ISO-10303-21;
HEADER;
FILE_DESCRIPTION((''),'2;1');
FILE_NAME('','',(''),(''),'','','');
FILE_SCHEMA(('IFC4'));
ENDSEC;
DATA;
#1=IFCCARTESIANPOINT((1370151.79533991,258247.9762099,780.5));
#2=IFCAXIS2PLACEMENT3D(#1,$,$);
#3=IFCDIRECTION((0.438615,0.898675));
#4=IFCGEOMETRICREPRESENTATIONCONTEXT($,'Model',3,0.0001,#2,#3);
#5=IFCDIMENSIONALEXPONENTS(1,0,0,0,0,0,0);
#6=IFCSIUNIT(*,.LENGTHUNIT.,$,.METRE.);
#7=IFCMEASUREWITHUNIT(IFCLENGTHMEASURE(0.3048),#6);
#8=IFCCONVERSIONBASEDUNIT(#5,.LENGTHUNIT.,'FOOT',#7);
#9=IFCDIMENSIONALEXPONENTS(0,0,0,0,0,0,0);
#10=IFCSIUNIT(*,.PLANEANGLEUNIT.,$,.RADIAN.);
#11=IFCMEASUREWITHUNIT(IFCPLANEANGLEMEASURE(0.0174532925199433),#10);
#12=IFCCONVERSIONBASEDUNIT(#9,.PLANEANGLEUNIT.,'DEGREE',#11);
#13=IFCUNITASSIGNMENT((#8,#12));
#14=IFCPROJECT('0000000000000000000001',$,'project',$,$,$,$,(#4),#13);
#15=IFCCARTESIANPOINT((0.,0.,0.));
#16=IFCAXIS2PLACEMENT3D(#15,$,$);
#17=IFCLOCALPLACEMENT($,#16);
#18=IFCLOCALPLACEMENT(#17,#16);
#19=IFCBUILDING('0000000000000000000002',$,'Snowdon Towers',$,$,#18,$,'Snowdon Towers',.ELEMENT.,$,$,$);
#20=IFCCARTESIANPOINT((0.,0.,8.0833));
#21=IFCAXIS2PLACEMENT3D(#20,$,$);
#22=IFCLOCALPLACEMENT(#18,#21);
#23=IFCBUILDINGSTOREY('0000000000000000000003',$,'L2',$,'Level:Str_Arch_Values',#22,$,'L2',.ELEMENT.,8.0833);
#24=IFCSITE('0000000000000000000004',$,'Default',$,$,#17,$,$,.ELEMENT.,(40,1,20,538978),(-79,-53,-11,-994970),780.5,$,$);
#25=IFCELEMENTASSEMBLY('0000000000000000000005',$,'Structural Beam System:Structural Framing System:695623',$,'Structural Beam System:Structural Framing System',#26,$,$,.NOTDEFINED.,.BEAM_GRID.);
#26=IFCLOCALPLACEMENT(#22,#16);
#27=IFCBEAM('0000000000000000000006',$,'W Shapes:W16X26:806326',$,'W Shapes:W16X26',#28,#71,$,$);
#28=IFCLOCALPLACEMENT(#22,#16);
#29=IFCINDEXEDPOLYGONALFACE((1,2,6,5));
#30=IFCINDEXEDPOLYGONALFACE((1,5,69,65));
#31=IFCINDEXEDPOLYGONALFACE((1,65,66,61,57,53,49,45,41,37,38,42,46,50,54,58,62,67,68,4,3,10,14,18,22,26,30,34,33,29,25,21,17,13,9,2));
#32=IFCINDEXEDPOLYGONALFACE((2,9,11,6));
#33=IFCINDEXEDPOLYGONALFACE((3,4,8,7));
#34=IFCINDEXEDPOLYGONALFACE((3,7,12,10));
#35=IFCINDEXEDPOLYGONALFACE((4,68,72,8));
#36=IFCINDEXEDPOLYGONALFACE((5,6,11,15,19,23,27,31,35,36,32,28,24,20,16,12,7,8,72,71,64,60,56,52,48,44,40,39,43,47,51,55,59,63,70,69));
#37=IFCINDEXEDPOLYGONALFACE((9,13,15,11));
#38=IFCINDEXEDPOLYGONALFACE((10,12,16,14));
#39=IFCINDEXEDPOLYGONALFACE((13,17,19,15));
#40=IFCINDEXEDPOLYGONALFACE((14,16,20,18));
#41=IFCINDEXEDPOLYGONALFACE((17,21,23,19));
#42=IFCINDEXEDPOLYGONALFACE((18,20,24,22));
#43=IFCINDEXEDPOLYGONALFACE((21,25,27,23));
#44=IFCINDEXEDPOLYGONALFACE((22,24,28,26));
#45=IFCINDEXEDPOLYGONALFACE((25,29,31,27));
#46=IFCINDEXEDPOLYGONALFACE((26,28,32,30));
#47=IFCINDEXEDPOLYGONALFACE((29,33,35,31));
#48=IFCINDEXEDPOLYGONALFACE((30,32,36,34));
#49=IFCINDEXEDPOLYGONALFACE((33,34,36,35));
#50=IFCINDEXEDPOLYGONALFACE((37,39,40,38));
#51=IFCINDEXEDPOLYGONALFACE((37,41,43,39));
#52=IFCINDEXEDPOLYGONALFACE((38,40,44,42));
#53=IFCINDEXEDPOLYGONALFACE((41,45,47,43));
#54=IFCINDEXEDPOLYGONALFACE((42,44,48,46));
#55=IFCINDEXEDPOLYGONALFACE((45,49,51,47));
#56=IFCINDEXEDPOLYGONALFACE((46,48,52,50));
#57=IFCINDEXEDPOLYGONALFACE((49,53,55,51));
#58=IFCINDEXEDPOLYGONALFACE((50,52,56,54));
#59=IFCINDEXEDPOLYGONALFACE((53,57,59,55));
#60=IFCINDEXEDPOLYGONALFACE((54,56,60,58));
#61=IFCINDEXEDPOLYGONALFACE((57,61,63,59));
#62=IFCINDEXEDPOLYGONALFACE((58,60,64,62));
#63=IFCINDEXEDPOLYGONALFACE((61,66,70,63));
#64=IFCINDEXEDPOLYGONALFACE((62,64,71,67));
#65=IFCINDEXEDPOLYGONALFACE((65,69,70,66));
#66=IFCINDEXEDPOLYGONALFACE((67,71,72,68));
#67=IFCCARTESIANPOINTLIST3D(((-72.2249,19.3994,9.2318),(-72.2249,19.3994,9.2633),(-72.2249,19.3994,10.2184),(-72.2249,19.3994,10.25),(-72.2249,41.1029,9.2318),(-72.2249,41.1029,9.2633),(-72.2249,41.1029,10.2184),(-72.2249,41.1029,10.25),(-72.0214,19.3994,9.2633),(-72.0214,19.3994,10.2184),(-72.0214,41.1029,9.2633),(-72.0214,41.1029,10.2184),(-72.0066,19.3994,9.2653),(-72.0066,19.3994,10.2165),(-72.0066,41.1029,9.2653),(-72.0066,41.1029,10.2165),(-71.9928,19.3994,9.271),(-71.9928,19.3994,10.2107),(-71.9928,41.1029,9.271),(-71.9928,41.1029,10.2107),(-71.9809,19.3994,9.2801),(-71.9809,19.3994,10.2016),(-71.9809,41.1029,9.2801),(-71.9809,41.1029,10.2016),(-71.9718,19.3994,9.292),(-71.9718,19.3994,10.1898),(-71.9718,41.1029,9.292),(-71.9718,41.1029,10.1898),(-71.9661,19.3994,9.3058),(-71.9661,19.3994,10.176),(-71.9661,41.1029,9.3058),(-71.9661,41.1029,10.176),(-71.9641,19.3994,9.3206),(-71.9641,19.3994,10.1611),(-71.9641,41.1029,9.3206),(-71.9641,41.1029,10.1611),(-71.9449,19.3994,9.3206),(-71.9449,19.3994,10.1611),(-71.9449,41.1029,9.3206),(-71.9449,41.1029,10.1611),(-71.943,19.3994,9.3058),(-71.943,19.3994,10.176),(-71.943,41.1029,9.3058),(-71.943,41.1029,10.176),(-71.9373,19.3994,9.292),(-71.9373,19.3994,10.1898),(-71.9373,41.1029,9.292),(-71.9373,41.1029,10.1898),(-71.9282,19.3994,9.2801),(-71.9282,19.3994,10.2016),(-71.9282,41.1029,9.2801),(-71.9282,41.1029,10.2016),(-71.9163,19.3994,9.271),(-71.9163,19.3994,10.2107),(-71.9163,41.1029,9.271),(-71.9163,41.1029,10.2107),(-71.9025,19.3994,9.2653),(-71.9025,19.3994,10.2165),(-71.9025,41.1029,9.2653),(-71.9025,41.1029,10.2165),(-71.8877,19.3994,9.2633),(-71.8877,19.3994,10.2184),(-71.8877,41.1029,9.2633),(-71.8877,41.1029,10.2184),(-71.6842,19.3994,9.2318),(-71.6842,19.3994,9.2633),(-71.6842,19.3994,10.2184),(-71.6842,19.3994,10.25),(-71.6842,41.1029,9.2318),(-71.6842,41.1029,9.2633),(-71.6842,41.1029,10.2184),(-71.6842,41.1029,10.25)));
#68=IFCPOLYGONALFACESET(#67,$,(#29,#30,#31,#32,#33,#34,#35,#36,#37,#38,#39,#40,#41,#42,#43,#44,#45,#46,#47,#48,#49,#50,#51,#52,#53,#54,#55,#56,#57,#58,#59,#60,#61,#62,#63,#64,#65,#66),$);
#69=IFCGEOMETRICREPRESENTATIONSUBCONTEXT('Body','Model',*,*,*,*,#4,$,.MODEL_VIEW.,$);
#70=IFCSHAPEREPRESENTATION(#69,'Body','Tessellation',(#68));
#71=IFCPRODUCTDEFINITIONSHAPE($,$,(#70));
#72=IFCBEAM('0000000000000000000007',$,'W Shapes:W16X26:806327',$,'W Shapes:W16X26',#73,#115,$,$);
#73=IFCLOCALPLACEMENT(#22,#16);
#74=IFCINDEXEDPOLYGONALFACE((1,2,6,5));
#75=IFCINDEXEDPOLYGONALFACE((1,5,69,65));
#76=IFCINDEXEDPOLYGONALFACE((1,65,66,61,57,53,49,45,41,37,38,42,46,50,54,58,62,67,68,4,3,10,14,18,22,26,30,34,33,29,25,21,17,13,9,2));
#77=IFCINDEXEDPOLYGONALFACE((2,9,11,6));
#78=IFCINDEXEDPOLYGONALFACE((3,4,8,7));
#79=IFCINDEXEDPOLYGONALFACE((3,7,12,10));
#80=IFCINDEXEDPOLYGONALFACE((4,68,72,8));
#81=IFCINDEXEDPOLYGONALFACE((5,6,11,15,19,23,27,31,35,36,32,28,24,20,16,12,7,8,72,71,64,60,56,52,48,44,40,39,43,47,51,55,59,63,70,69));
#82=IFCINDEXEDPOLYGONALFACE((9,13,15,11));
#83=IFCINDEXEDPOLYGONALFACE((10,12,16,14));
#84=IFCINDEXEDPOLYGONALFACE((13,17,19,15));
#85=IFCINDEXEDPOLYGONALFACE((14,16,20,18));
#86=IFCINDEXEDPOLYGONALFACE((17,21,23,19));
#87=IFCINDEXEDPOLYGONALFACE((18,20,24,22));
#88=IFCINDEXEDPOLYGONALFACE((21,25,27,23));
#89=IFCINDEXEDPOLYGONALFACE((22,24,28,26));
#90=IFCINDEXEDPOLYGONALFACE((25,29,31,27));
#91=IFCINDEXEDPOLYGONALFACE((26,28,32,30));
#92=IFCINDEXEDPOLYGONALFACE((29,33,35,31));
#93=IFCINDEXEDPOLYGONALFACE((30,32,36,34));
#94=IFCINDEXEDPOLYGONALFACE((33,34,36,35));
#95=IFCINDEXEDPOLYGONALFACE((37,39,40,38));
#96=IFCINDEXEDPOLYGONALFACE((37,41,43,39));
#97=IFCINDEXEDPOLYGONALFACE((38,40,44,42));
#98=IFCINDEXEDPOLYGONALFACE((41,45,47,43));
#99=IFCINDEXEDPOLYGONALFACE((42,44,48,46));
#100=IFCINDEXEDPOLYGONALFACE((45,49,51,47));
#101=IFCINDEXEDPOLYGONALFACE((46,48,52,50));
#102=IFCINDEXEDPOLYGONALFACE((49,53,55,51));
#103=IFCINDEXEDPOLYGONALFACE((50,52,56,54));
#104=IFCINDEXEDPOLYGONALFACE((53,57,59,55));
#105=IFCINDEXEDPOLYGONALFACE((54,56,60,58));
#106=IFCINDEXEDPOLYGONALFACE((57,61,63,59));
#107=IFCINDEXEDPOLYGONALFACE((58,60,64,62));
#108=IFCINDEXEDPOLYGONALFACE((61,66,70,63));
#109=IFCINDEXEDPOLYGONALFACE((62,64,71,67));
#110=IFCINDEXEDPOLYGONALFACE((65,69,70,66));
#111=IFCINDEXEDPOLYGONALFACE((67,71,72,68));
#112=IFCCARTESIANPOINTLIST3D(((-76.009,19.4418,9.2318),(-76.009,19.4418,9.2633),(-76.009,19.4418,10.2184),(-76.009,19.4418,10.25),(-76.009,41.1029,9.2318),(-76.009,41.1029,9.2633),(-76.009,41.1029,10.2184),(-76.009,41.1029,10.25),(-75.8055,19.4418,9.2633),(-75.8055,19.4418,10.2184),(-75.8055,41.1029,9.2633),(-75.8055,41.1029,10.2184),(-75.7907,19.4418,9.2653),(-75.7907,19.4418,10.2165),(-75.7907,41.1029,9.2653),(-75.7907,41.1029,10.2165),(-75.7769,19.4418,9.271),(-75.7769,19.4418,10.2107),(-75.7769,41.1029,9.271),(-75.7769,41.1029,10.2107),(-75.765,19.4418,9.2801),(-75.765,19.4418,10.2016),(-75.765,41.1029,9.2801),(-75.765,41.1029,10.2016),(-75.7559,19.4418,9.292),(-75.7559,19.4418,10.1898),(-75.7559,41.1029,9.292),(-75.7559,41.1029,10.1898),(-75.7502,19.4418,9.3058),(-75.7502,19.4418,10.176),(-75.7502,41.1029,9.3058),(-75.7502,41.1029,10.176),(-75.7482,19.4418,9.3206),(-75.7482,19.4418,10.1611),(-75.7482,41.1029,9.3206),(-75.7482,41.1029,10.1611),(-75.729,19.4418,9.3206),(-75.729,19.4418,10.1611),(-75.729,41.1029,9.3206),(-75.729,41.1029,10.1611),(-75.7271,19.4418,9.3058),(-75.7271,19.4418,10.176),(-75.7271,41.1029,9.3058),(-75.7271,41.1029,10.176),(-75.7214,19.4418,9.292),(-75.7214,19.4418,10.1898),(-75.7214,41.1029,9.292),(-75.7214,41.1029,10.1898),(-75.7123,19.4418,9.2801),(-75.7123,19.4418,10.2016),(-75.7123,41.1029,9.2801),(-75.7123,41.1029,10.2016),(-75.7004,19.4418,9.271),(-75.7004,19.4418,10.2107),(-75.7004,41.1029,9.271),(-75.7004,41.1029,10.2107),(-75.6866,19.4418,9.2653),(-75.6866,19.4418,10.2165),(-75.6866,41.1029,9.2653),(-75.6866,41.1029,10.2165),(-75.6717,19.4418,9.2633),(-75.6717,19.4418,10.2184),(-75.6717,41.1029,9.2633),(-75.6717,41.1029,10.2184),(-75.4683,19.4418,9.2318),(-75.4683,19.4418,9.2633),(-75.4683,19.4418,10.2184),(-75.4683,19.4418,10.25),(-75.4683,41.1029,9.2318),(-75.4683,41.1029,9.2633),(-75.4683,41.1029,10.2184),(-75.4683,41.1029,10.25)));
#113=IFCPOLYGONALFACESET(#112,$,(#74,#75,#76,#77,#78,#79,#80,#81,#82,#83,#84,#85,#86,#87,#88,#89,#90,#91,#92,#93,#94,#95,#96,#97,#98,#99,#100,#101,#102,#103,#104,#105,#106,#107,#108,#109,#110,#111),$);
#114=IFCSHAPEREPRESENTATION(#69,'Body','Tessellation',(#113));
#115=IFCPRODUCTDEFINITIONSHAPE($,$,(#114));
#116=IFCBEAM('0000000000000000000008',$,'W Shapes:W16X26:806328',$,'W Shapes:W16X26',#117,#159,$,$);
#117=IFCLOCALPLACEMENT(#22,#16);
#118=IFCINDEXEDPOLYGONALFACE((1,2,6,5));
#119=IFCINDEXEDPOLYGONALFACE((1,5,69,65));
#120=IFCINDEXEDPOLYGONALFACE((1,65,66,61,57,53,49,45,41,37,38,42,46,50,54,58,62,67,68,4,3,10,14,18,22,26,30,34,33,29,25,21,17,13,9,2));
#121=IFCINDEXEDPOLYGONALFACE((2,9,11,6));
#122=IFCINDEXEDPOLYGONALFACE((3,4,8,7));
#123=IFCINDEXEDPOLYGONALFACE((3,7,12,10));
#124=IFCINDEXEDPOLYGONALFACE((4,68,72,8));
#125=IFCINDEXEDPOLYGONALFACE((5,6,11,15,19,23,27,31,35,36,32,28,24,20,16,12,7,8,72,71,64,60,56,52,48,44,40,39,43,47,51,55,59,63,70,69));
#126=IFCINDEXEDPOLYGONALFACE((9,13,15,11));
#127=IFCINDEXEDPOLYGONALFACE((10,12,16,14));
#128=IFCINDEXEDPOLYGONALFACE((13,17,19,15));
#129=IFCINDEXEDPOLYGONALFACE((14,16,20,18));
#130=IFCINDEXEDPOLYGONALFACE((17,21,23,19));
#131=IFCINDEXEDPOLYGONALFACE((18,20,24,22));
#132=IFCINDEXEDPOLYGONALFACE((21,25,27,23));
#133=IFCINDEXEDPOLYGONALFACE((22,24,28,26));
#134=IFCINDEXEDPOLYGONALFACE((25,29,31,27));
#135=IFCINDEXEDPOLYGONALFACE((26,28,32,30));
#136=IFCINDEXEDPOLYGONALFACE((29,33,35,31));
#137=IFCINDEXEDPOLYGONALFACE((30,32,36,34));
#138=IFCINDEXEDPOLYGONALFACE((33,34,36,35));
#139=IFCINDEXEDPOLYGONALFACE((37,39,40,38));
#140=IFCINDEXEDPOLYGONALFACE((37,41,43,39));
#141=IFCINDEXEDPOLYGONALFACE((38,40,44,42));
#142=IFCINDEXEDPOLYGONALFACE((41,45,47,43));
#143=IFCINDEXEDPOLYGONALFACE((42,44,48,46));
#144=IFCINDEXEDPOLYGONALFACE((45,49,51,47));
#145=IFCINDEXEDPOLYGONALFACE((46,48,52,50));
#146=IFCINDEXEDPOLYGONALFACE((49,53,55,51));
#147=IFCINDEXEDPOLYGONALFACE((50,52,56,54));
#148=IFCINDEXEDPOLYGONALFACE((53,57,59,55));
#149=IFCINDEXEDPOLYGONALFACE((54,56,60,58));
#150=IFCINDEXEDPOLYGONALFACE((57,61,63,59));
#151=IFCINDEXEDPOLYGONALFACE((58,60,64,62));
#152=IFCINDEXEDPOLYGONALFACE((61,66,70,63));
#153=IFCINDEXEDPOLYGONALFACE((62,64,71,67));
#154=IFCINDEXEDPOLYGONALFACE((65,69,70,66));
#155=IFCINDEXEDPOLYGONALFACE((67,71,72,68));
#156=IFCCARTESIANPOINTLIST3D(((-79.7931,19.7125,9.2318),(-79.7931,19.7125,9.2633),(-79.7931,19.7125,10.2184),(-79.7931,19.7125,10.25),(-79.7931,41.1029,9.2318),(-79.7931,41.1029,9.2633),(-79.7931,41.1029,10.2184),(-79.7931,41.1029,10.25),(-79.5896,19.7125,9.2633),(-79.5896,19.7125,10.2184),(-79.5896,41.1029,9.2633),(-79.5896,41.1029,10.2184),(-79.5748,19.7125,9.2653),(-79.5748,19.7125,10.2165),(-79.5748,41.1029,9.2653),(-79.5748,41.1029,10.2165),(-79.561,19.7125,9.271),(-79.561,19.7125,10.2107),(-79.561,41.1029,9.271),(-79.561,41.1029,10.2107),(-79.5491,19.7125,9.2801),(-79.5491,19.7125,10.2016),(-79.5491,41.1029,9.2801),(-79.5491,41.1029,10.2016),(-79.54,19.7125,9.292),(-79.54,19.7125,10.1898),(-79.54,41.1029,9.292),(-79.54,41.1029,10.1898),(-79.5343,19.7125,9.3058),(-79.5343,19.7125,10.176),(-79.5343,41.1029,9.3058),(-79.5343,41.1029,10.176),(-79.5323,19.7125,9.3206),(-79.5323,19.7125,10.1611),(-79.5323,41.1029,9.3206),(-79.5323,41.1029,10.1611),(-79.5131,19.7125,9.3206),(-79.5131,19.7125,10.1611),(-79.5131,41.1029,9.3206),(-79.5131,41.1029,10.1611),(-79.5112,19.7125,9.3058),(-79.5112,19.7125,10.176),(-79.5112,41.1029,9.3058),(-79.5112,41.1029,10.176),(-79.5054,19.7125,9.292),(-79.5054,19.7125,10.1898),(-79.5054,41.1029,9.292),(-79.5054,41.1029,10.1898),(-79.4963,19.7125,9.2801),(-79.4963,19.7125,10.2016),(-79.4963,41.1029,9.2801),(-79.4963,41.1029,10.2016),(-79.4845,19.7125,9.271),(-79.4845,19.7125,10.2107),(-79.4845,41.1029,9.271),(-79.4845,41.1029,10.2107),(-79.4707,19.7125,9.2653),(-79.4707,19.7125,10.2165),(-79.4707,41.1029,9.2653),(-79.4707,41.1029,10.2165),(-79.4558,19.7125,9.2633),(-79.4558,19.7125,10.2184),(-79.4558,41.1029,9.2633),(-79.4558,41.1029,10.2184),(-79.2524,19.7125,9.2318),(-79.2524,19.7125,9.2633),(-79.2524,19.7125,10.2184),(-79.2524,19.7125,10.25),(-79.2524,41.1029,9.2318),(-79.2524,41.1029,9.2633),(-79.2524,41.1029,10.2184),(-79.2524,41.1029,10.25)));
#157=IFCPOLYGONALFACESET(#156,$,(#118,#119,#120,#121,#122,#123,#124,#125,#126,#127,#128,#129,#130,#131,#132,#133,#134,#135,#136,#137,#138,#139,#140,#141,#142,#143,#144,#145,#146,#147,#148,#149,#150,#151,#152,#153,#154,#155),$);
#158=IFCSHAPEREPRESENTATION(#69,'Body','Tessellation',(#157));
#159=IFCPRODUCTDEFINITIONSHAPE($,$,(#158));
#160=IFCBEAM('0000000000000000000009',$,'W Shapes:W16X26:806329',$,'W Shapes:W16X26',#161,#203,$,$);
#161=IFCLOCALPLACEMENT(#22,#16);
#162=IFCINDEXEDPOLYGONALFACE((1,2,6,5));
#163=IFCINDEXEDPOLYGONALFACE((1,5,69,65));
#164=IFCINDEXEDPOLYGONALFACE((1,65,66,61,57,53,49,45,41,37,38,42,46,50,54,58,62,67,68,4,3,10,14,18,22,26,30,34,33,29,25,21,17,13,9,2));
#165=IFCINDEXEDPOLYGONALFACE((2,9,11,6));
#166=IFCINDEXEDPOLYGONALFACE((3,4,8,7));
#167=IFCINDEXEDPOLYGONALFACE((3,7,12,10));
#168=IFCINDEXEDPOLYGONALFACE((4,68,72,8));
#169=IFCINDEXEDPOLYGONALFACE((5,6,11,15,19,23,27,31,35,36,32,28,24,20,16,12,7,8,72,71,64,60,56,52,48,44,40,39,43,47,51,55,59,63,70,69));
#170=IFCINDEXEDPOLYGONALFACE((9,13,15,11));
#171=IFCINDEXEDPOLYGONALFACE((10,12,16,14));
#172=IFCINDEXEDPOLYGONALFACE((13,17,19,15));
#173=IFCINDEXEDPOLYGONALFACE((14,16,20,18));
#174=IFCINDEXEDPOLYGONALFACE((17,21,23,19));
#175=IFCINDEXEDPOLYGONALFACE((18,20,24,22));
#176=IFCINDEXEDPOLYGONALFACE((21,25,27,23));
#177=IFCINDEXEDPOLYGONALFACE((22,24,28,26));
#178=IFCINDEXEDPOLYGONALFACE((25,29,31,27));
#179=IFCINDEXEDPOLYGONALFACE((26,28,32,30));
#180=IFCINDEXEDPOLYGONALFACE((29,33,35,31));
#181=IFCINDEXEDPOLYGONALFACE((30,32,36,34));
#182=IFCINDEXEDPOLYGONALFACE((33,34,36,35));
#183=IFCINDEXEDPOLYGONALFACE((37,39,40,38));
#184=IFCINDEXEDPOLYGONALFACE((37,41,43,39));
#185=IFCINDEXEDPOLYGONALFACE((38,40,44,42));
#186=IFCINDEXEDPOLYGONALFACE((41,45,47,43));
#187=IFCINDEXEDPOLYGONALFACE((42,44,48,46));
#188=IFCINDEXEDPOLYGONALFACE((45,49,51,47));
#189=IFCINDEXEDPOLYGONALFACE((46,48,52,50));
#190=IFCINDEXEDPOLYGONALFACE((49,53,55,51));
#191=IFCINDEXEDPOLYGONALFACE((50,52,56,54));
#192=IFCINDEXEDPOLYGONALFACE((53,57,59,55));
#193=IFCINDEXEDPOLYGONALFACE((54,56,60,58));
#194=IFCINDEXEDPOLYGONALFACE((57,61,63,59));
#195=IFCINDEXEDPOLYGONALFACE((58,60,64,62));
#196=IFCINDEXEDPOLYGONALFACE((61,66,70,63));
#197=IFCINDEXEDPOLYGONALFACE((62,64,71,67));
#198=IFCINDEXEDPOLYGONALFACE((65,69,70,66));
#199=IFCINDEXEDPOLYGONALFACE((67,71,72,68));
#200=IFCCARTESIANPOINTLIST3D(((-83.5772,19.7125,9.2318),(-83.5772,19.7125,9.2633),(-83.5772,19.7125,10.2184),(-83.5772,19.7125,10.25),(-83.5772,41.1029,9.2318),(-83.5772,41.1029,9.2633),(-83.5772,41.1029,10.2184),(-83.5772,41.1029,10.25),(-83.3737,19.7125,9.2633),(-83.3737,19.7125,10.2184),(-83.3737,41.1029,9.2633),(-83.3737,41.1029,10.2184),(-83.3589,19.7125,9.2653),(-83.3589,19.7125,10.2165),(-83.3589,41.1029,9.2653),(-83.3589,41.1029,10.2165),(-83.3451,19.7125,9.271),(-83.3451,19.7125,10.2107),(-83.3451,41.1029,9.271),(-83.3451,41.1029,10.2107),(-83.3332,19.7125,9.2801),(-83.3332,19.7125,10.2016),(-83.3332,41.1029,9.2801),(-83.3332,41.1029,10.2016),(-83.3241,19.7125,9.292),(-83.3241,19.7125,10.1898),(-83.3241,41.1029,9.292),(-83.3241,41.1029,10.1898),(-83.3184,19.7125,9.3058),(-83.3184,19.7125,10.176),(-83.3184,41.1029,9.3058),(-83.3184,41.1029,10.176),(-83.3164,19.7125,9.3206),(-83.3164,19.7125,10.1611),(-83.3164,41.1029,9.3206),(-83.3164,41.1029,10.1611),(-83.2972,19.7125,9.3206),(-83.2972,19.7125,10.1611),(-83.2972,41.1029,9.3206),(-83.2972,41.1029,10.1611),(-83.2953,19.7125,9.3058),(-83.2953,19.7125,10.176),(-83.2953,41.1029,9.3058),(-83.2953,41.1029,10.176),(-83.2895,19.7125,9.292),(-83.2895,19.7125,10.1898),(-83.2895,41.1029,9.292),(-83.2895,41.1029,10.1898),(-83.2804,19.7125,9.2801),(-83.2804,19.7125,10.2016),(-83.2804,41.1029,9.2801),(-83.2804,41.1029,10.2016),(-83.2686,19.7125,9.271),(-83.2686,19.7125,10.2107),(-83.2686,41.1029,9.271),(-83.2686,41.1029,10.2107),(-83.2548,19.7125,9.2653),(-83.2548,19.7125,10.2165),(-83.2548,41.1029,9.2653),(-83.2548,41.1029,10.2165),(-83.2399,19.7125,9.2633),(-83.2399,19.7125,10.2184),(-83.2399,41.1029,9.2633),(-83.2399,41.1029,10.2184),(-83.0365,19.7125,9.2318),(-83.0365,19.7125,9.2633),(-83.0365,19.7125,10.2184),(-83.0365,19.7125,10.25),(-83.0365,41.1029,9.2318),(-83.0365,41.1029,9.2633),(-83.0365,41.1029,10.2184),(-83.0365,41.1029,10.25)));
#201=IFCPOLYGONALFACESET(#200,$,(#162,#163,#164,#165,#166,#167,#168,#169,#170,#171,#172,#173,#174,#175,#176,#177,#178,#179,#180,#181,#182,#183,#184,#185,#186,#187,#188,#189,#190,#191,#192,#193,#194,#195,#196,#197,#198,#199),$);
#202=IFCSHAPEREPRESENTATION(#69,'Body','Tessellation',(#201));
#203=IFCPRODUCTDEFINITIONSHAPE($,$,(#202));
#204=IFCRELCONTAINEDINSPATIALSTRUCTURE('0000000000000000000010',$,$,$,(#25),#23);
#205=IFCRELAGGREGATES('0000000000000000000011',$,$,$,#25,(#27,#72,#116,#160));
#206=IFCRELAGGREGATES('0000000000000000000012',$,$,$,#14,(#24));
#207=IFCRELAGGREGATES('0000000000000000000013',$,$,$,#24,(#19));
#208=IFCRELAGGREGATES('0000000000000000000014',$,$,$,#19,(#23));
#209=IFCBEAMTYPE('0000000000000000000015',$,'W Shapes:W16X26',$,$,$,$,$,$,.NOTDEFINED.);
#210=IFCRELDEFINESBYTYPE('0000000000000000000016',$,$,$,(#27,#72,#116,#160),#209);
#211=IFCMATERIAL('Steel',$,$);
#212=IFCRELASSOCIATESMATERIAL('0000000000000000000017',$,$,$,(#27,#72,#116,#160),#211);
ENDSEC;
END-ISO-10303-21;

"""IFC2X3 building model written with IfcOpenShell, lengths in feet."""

from ifc_helpers import new_model, entity, si_unit, converted_unit, direction, frame, frame_2d, origin, place, context, subcontext, project, spatial, i_section, extrude, material, type_object, element, aggregate, save


model = new_model("IFC2X3")

# Units and contexts
model_context = context("Model", 3, precision=0.0001, world=frame((1370151.79533991, 258247.9762099, 780.5)), true_north=direction((0.438615, 0.898675)))
body_context = subcontext(model_context, "Body", "Model", "MODEL_VIEW")
ifc_project = project(units=[converted_unit("LENGTHUNIT", "FOOT", entity("IfcLengthMeasure", 0.3048), si_unit("LENGTHUNIT", "METRE"), dimensions=[1, 0, 0, 0, 0, 0, 0]), converted_unit("PLANEANGLEUNIT", "DEGREE", entity("IfcPlaneAngleMeasure", 0.0174532925199433), si_unit("PLANEANGLEUNIT", "RADIAN"), dimensions=[0, 0, 0, 0, 0, 0, 0])], contexts=[model_context])

# Site, building, storey
site_placement = place(None, origin())
site = spatial("IfcSite", under=ifc_project, at=site_placement, Name="Default", CompositionType="ELEMENT", RefLatitude=(40, 1, 20, 538978), RefLongitude=(-79, -53, -11, -994970), RefElevation=780.5)
building_placement = place(site_placement, origin())
building = spatial("IfcBuilding", under=site, at=building_placement, Name="Snowdon Towers", LongName="Snowdon Towers", CompositionType="ELEMENT")
storey_placement = place(building_placement, frame((0.0, 0.0, 8.0833)))
storey = spatial("IfcBuildingStorey", under=building, at=storey_placement, Name="L2", ObjectType="Level:Str_Arch_Values", LongName="L2", CompositionType="ELEMENT", Elevation=8.0833)

# Shared definitions
ifc_material = material(Name="Steel")

# Element assembly, beams
assembly_1_placement = place(storey_placement, origin())
assembly_1 = element("IfcElementAssembly", 1, at=assembly_1_placement, inside=storey, Name="Structural Beam System:Structural Framing System:695623", ObjectType="Structural Beam System:Structural Framing System", AssemblyPlace="NOTDEFINED", PredefinedType="BEAM_GRID")
beam_type_1 = type_object("IfcBeamType", Name="W Shapes:W16X26", PredefinedType="NOTDEFINED")
beam_1_placement = place(assembly_1_placement, frame((-71.9545, 41.4583, 10.25), z_axis=(0.0, 0.0, 1.0), x_axis=(0.0, -1.0, 0.0)))
beam_1 = element("IfcBeam", 2, at=beam_1_placement, type_object=beam_type_1, material=ifc_material, Name="W Shapes:W16X26:806326", ObjectType="W Shapes:W16X26", context=body_context, shape_type="SweptSolid", body=[
    extrude(i_section(OverallWidth=0.5407, OverallDepth=1.0182, WebThickness=0.0192, FlangeThickness=0.0316, FilletRadius=0.0573, at=frame_2d((0.0, 0.0), x_axis=(0.0, 1.0))), frame((0.3554, 0.0, -0.5091), z_axis=(1.0, 0.0, 0.0), x_axis=(0.0, 0.0, -1.0)), (0.0, 0.0, 1.0), 21.7035),
])
beam_2_placement = place(assembly_1_placement, frame((-75.7386, 41.4583, 10.25), z_axis=(0.0, 0.0, 1.0), x_axis=(0.0, -1.0, 0.0)))
beam_2 = element("IfcBeam", 3, at=beam_2_placement, type_object=beam_type_1, material=ifc_material, Name="W Shapes:W16X26:806327", ObjectType="W Shapes:W16X26", context=body_context, shape_type="SweptSolid", body=[
    extrude(i_section(OverallWidth=0.5407, OverallDepth=1.0182, WebThickness=0.0192, FlangeThickness=0.0316, FilletRadius=0.0573, at=frame_2d((0.0, 0.0), x_axis=(0.0, 1.0))), frame((0.3554, 0.0, -0.5091), z_axis=(1.0, 0.0, 0.0), x_axis=(0.0, 0.0, -1.0)), (0.0, 0.0, 1.0), 21.6611),
])
beam_3_placement = place(assembly_1_placement, frame((-79.5227, 41.4583, 10.25), z_axis=(0.0, 0.0, 1.0), x_axis=(0.0, -1.0, 0.0)))
beam_3 = element("IfcBeam", 4, at=beam_3_placement, type_object=beam_type_1, material=ifc_material, Name="W Shapes:W16X26:806328", ObjectType="W Shapes:W16X26", context=body_context, shape_type="SweptSolid", body=[
    extrude(i_section(OverallWidth=0.5407, OverallDepth=1.0182, WebThickness=0.0192, FlangeThickness=0.0316, FilletRadius=0.0573, at=frame_2d((0.0, 0.0), x_axis=(0.0, 1.0))), frame((0.3554, 0.0, -0.5091), z_axis=(1.0, 0.0, 0.0), x_axis=(0.0, 0.0, -1.0)), (0.0, 0.0, 1.0), 21.3904),
])
beam_4_placement = place(assembly_1_placement, frame((-83.3068, 41.4583, 10.25), z_axis=(0.0, 0.0, 1.0), x_axis=(0.0, -1.0, 0.0)))
beam_4 = element("IfcBeam", 5, at=beam_4_placement, type_object=beam_type_1, material=ifc_material, Name="W Shapes:W16X26:806329", ObjectType="W Shapes:W16X26", context=body_context, shape_type="SweptSolid", body=[
    extrude(i_section(OverallWidth=0.5407, OverallDepth=1.0182, WebThickness=0.0192, FlangeThickness=0.0316, FilletRadius=0.0573, at=frame_2d((0.0, 0.0), x_axis=(0.0, 1.0))), frame((0.3554, 0.0, -0.5091), z_axis=(1.0, 0.0, 0.0), x_axis=(0.0, 0.0, -1.0)), (0.0, 0.0, 1.0), 21.3904),
])
aggregate(assembly_1, [beam_1, beam_2, beam_3, beam_4])

save(model, "model.ifc")
